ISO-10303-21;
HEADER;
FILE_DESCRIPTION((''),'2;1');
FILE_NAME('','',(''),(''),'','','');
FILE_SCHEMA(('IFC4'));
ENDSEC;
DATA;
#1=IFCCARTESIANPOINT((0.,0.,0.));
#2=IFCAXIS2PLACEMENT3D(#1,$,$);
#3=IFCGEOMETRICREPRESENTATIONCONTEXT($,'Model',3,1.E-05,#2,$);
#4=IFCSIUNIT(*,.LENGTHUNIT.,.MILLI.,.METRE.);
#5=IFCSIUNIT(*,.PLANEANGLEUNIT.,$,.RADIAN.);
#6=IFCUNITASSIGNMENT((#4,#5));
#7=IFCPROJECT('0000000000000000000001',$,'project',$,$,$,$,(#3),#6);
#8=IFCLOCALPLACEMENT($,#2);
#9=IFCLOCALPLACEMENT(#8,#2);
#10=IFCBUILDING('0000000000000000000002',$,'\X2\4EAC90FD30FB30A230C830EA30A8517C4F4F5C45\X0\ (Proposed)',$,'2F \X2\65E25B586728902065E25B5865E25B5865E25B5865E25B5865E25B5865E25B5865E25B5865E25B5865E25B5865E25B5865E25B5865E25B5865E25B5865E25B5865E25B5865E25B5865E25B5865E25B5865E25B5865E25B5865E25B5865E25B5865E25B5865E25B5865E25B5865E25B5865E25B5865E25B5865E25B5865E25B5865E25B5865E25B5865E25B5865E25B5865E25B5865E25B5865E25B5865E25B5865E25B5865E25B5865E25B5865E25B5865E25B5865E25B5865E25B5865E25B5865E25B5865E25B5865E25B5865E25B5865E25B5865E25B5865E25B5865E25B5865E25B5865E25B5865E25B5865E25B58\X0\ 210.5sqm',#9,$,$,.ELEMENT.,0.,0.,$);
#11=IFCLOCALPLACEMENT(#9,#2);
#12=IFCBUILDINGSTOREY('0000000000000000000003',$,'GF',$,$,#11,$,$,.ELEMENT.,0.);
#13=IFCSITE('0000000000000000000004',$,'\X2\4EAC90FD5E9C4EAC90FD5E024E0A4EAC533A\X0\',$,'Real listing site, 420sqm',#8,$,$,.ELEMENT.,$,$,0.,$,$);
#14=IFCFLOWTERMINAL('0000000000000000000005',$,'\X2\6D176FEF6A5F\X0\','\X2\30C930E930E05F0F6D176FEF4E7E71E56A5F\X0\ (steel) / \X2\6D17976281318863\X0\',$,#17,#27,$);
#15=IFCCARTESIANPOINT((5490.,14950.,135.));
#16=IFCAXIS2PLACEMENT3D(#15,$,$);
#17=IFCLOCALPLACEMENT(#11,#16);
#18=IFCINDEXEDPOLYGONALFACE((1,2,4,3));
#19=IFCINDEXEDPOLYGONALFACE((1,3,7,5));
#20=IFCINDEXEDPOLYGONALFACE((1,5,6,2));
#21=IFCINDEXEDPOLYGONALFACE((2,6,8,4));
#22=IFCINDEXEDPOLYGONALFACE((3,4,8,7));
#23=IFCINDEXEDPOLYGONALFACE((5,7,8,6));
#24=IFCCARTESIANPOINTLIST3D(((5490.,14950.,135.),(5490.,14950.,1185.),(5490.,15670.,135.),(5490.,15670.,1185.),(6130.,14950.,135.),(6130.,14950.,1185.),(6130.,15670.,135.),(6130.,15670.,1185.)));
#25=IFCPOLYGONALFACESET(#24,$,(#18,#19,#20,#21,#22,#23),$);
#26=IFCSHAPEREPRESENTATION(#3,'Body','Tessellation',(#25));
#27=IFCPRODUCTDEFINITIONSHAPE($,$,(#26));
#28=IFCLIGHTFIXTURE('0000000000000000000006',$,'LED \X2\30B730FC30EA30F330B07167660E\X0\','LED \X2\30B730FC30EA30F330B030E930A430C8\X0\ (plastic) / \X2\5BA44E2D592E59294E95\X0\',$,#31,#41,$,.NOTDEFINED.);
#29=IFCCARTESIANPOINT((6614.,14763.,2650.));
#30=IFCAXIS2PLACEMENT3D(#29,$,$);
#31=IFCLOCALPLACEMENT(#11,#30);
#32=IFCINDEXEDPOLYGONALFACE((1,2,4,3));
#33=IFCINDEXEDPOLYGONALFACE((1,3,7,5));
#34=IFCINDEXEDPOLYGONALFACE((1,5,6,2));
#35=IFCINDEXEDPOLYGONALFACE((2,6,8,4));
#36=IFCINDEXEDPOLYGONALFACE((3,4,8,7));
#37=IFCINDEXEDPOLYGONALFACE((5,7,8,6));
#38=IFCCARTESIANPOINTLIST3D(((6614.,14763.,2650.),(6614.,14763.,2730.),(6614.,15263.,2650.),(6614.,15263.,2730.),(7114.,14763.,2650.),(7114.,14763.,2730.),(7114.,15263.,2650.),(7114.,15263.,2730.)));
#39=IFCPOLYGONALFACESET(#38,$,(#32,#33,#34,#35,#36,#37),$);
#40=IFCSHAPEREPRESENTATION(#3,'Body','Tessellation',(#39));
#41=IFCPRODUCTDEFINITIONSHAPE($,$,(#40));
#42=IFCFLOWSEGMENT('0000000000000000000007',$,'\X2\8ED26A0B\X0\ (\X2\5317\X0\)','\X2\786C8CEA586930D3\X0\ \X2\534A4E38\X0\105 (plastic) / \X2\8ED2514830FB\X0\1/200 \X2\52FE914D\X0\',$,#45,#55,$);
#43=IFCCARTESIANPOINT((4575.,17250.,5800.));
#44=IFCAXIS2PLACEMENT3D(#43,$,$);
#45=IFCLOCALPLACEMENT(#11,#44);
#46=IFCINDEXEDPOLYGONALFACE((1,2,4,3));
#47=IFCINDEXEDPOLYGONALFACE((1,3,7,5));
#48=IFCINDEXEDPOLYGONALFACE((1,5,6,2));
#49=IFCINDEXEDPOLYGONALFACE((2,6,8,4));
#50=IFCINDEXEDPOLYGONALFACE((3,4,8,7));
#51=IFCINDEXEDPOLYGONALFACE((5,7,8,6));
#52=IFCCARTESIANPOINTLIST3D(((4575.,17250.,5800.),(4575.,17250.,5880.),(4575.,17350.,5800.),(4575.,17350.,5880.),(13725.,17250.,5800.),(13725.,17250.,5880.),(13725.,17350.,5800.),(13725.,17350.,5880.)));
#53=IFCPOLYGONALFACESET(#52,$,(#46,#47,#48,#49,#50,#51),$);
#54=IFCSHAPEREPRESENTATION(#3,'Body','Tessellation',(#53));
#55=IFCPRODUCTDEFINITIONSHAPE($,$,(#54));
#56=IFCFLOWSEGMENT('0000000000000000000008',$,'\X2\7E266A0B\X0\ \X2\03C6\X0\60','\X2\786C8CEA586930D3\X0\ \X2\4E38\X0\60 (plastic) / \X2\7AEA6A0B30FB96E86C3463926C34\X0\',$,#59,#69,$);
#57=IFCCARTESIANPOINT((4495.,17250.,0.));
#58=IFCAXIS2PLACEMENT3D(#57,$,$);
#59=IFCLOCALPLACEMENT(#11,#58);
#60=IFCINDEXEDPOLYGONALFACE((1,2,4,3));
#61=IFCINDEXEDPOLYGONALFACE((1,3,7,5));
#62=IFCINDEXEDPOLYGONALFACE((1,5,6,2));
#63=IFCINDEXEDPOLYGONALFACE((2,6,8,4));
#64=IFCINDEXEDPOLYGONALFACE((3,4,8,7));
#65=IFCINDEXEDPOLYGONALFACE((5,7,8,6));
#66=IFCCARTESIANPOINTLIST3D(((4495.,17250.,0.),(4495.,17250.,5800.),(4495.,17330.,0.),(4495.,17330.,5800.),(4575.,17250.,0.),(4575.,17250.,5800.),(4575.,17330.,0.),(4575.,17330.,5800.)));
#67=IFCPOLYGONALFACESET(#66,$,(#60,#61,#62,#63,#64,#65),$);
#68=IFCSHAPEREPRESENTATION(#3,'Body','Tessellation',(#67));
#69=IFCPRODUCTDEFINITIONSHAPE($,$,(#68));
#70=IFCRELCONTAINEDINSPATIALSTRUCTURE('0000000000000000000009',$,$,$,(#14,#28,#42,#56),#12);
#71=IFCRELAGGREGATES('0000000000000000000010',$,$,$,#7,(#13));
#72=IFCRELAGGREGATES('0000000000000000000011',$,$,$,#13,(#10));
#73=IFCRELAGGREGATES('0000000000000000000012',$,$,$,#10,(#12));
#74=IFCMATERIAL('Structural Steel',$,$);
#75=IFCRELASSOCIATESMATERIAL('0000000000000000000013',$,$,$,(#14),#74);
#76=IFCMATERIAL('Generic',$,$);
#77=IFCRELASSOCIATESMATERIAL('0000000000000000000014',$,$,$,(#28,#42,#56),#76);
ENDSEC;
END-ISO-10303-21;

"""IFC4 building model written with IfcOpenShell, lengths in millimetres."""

from ifc_helpers import new_model, si_unit, frame, frame_2d, origin, place, context, project, spatial, rectangle, extrude, material, element, save


model = new_model("IFC4")

# Units and contexts
model_context = context("Model", 3, precision=1e-05, world=origin())
ifc_project = project(units=[si_unit("LENGTHUNIT", "METRE", prefix="MILLI"), si_unit("PLANEANGLEUNIT", "RADIAN")], contexts=[model_context])

# Site, building, storey
site_placement = place(None, origin())
site = spatial("IfcSite", under=ifc_project, at=site_placement, Name="京都府京都市上京区", ObjectType="Real listing site, 420sqm", CompositionType="ELEMENT", RefElevation=0.0)
building_placement = place(site_placement, origin())
building = spatial("IfcBuilding", under=site, at=building_placement, Name="京都・アトリエ兼住居 (Proposed)", ObjectType="2F 既存木造既存既存既存既存既存既存既存既存既存既存既存既存既存既存既存既存既存既存既存既存既存既存既存既存既存既存既存既存既存既存既存既存既存既存既存既存既存既存既存既存既存既存既存既存既存既存既存既存既存既存既存既存既存既存既存既存既存既存 210.5sqm", CompositionType="ELEMENT", ElevationOfRefHeight=0.0, ElevationOfTerrain=0.0)
storey_placement = place(building_placement, origin())
storey = spatial("IfcBuildingStorey", under=building, at=storey_placement, Name="GF", CompositionType="ELEMENT", Elevation=0.0)

# Flow terminal
ifc_material_1 = material(Name="Structural Steel")
flow_terminal_placement = place(storey_placement, frame((5490.0, 14950.0, 135.0)))
element("IfcFlowTerminal", 1, at=flow_terminal_placement, inside=storey, material=ifc_material_1, Name="洗濯機", Description="ドラム式洗濯乾燥機 (steel) / 洗面脱衣", context=model_context, shape_type="SweptSolid", body=[
    extrude(rectangle(XDim=640.0, YDim=720.0, at=frame_2d((320.0, 360.0))), frame((5490.0, 14950.0, 135.0)), (0.0, 0.0, 1.0), 1050.0),
])

# Light fixture
ifc_material_2 = material(Name="Generic")
light_fixture_placement = place(storey_placement, frame((6614.0, 14763.0, 2650.0)))
element("IfcLightFixture", 2, at=light_fixture_placement, inside=storey, material=ifc_material_2, Name="LED シーリング照明", Description="LED シーリングライト (plastic) / 室中央天井", PredefinedType="NOTDEFINED", context=model_context, shape_type="SweptSolid", body=[
    extrude(rectangle(XDim=500.0, YDim=500.0, at=frame_2d((250.0, 250.0))), frame((6614.0, 14763.0, 2650.0)), (0.0, 0.0, 1.0), 80.0),
])

# Flow segments
flow_segment_1_placement = place(storey_placement, frame((4575.0, 17250.0, 5800.0)))
element("IfcFlowSegment", 3, at=flow_segment_1_placement, inside=storey, material=ifc_material_2, Name="軒樋 (北)", Description="硬質塩ビ 半丸105 (plastic) / 軒先・1/200 勾配", context=model_context, shape_type="SweptSolid", body=[
    extrude(rectangle(XDim=9150.0, YDim=100.0, at=frame_2d((4575.0, 50.0))), frame((4575.0, 17250.0, 5800.0)), (0.0, 0.0, 1.0), 80.0),
])
flow_segment_2_placement = place(storey_placement, frame((4495.0, 17250.0, 0.0)))
element("IfcFlowSegment", 4, at=flow_segment_2_placement, inside=storey, material=ifc_material_2, Name="縦樋 φ60", Description="硬質塩ビ 丸60 (plastic) / 竪樋・雨水排水", context=model_context, shape_type="SweptSolid", body=[
    extrude(rectangle(XDim=80.0, YDim=80.0, at=frame_2d((40.0, 40.0))), frame((4495.0, 17250.0, 0.0)), (0.0, 0.0, 1.0), 5800.0),
])

save(model, "model.ifc")
